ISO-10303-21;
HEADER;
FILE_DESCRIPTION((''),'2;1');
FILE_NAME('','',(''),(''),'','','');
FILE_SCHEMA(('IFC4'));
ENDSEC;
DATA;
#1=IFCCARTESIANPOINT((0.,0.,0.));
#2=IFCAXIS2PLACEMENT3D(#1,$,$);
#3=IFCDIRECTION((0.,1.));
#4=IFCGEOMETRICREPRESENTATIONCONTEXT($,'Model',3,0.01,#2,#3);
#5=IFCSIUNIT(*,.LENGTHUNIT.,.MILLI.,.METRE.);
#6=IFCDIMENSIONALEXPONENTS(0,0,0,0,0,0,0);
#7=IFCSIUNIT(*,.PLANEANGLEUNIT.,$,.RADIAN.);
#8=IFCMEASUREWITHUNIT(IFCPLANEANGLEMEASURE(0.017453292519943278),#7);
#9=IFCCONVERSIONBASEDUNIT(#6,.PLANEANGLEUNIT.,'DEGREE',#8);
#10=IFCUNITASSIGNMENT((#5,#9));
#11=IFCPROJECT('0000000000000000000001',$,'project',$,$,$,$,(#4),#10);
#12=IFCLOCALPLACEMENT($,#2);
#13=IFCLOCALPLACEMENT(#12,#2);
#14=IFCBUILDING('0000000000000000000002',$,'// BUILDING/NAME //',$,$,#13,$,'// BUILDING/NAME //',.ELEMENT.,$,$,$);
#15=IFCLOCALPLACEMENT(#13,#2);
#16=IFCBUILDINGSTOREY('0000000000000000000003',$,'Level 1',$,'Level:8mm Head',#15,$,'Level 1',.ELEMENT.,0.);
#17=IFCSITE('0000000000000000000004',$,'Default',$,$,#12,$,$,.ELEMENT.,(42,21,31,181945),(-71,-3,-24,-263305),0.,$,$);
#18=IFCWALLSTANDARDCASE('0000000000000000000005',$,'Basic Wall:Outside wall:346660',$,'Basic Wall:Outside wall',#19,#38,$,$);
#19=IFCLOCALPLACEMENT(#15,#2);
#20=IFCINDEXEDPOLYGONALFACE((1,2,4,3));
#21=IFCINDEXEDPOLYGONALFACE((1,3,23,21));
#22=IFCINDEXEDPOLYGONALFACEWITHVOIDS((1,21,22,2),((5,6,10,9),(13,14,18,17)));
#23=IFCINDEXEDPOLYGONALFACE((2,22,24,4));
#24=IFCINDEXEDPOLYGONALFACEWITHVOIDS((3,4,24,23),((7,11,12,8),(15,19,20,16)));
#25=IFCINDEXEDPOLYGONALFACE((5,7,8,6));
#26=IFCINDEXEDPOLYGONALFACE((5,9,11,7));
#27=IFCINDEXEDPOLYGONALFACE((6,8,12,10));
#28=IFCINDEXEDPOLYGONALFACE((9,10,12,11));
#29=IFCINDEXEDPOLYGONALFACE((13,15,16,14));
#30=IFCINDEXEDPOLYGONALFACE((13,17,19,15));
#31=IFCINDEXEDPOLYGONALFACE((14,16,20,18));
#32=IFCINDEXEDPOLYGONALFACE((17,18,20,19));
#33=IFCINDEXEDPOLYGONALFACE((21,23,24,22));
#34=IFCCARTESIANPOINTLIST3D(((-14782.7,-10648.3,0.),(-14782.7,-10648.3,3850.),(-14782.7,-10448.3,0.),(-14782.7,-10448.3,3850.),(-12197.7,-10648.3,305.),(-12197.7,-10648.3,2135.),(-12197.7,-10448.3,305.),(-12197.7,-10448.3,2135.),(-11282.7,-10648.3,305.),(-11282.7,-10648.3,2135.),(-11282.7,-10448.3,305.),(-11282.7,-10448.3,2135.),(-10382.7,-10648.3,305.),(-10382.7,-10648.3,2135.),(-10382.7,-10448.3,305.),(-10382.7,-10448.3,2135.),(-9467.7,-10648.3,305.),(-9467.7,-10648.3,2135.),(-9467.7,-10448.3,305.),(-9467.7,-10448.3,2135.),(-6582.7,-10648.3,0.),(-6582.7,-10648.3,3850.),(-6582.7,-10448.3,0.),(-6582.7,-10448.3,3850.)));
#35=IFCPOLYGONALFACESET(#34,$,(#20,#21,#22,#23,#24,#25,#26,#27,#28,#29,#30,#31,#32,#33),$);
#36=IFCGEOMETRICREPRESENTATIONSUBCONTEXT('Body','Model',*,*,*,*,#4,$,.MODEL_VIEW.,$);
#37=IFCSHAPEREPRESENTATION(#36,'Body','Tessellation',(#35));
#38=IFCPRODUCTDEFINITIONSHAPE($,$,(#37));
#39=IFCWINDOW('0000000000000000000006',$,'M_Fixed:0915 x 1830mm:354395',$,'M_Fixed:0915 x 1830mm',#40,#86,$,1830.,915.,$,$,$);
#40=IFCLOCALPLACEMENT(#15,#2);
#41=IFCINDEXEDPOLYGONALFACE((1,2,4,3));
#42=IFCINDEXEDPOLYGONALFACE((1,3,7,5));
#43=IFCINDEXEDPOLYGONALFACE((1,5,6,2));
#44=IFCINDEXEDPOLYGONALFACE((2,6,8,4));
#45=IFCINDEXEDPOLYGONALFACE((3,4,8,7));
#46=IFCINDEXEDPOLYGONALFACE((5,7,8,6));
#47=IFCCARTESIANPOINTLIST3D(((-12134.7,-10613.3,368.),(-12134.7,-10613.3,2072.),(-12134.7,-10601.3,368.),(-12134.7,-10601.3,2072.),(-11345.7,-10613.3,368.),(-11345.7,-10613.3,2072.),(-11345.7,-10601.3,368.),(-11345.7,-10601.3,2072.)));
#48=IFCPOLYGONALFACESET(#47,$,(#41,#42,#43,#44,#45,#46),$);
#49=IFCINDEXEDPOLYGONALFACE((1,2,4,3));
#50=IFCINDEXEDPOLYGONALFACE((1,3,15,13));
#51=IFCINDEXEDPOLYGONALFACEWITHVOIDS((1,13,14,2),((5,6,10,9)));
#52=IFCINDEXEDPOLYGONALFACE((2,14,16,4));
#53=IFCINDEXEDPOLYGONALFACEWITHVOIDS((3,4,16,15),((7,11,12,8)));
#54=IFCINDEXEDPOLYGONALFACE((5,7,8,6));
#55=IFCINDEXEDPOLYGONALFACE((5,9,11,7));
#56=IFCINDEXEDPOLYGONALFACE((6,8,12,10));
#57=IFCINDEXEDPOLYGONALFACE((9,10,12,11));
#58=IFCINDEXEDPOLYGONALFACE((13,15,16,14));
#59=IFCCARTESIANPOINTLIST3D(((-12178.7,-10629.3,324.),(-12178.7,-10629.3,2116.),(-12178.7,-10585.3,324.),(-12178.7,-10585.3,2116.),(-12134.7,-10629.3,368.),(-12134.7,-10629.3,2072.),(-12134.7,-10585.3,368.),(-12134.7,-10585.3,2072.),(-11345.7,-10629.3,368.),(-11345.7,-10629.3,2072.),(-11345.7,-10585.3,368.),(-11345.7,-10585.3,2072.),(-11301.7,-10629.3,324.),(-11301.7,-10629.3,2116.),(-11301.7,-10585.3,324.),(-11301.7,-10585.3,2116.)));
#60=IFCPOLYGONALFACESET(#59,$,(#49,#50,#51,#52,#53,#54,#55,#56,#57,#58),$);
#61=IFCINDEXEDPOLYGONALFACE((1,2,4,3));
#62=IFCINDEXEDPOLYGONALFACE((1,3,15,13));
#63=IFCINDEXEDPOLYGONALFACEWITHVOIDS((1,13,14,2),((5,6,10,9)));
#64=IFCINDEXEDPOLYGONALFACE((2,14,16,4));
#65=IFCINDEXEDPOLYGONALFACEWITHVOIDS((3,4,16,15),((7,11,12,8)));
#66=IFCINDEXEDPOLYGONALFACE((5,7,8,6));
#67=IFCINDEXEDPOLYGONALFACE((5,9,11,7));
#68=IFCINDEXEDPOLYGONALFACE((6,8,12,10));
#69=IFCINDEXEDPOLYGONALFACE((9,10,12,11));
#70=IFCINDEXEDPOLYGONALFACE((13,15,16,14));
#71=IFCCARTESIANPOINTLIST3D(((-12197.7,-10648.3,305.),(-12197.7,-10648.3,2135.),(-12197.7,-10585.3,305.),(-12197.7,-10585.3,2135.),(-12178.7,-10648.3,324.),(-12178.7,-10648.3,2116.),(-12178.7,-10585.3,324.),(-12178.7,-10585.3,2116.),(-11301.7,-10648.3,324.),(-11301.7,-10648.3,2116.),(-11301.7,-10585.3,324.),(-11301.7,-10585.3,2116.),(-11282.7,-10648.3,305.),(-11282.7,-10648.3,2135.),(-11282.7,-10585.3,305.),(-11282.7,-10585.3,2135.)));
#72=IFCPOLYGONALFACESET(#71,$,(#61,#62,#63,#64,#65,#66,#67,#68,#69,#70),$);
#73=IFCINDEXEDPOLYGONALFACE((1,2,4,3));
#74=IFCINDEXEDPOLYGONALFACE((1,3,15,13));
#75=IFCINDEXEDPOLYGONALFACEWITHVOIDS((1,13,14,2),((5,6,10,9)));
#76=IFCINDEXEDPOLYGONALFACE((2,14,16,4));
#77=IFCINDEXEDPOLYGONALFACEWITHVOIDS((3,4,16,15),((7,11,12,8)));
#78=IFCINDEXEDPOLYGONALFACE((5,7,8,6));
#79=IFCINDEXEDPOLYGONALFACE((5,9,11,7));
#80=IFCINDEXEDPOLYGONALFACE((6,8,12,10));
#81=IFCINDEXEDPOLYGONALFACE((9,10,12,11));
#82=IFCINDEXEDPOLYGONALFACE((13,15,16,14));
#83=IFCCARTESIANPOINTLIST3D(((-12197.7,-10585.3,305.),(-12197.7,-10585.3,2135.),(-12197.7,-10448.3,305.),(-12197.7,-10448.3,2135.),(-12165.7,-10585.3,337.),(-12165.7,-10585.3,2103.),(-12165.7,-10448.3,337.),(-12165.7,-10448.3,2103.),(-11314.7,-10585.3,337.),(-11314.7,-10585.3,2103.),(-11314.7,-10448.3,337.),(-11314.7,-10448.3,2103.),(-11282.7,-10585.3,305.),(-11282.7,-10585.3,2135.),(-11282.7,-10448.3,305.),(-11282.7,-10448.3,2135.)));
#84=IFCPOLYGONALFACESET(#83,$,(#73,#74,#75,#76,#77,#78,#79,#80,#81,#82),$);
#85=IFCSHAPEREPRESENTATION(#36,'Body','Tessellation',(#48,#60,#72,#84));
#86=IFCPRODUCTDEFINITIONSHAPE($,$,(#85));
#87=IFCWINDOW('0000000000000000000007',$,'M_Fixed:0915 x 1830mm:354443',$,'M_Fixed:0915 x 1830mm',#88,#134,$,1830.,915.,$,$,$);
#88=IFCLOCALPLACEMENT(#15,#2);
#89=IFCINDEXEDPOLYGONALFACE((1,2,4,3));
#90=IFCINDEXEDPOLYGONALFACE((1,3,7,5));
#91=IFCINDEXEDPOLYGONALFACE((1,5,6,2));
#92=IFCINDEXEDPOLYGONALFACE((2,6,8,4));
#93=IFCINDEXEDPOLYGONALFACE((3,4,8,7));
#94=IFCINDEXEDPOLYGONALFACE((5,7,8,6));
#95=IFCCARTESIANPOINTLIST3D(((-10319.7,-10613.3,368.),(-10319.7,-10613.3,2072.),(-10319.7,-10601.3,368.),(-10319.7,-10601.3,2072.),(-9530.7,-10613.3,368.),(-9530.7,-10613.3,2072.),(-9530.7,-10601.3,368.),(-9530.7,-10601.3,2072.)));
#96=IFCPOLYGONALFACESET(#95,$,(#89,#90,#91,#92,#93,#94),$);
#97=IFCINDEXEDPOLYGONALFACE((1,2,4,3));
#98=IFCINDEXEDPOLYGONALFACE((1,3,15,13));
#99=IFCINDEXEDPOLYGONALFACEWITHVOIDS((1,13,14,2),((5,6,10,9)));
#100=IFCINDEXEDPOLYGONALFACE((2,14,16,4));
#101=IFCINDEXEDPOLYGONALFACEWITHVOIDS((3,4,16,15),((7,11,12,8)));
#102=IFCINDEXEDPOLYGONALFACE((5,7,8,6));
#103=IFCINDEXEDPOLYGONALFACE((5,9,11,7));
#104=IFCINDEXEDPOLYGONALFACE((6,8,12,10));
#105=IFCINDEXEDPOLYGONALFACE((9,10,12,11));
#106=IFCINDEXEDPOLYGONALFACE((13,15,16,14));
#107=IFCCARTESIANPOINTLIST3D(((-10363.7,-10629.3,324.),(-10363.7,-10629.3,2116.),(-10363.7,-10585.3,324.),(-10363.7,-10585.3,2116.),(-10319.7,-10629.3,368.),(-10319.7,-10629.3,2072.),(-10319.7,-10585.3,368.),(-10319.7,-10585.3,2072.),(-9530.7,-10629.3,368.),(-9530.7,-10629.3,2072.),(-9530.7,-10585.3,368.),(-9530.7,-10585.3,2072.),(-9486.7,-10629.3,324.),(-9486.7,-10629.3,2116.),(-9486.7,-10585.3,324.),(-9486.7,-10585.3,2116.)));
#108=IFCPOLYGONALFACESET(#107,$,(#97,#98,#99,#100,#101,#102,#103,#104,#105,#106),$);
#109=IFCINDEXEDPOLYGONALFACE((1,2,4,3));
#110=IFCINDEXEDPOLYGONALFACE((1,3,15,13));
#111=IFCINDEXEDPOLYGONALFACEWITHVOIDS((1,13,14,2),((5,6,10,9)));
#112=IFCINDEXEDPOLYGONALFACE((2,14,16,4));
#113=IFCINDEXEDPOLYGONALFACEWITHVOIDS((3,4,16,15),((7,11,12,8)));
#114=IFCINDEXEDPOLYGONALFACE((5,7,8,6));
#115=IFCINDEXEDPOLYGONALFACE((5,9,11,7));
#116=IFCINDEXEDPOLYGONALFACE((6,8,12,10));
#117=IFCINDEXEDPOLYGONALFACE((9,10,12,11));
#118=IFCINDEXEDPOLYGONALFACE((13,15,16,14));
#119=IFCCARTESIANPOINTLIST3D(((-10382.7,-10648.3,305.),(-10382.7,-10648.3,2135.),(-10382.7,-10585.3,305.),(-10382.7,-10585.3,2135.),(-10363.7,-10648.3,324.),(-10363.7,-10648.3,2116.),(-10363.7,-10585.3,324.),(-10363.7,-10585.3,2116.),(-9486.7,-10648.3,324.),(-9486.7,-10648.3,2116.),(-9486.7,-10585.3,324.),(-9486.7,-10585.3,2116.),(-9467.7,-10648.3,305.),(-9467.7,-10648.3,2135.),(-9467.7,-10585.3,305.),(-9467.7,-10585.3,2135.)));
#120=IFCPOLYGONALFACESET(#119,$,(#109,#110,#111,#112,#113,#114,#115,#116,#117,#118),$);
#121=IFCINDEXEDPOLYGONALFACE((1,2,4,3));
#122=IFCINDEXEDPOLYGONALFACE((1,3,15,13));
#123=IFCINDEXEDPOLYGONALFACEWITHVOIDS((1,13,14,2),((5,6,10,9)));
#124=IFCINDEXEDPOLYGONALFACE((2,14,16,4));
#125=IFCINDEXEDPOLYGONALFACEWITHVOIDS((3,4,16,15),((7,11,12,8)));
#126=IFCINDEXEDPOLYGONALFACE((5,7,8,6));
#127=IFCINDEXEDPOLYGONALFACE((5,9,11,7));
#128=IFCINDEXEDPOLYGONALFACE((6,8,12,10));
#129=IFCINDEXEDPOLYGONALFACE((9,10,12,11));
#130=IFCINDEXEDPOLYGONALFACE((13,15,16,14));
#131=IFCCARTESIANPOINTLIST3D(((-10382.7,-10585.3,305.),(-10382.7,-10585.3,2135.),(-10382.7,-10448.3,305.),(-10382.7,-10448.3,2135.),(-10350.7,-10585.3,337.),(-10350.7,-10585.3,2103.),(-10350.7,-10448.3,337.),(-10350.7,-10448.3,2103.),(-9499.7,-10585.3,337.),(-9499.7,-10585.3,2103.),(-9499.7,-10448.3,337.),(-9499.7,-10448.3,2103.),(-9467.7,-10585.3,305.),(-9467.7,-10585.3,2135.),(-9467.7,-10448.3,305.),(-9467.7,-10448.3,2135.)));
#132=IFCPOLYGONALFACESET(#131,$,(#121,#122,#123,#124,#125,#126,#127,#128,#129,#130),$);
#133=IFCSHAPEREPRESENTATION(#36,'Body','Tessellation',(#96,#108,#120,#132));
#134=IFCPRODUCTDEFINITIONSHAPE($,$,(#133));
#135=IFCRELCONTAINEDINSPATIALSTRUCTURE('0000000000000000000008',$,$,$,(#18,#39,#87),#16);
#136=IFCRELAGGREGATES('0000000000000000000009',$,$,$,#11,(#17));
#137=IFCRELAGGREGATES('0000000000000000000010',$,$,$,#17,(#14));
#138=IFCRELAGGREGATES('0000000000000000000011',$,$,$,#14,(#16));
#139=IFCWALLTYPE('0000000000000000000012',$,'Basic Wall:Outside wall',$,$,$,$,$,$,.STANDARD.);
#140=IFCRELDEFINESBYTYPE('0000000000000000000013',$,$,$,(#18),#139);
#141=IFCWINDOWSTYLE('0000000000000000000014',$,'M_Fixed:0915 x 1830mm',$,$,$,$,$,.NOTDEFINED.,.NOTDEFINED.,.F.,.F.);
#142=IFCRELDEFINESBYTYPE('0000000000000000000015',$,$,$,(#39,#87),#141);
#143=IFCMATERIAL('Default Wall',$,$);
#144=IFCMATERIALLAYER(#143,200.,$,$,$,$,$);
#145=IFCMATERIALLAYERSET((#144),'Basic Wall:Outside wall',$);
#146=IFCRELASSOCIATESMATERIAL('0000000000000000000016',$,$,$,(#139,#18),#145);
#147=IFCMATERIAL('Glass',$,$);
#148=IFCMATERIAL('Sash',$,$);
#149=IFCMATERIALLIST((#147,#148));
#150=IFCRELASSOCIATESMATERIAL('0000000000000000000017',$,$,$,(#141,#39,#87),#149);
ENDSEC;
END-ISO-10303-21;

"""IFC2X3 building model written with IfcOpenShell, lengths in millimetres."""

from ifc_helpers import new_model, entity, si_unit, converted_unit, direction, frame, frame_2d, origin, place, context, subcontext, project, spatial, polyline, rectangle, outline, extrude, clip, bounded_halfspace, source, transform, mapped, material, material_list, layer, layer_set, layer_usage, type_object, type_shapes, element, fill, save


model = new_model("IFC2X3")

# Units and contexts
model_context = context("Model", 3, precision=0.01, world=origin(), true_north=direction((0.0, 1.0)))
body_context = subcontext(model_context, "Body", "Model", "MODEL_VIEW")
ifc_project = project(units=[si_unit("LENGTHUNIT", "METRE", prefix="MILLI"), converted_unit("PLANEANGLEUNIT", "DEGREE", entity("IfcPlaneAngleMeasure", 0.017453292519943278), si_unit("PLANEANGLEUNIT", "RADIAN"), dimensions=[0, 0, 0, 0, 0, 0, 0])], contexts=[model_context])

# Site, building, storey
site_placement = place(None, origin())
site = spatial("IfcSite", under=ifc_project, at=site_placement, Name="Default", CompositionType="ELEMENT", RefLatitude=(42, 21, 31, 181945), RefLongitude=(-71, -3, -24, -263305), RefElevation=0.0)
building_placement = place(site_placement, origin())
building = spatial("IfcBuilding", under=site, at=building_placement, Name="// BUILDING/NAME //", LongName="// BUILDING/NAME //", CompositionType="ELEMENT")
storey_placement = place(building_placement, origin())
storey = spatial("IfcBuildingStorey", under=building, at=storey_placement, Name="Level 1", ObjectType="Level:8mm Head", LongName="Level 1", CompositionType="ELEMENT", Elevation=0.0)

# Wall, openings, windows
ifc_material_1 = material(Name="Default Wall")
ifc_layer = layer(ifc_material_1, 200.0)
ifc_layer_set = layer_set([ifc_layer], Name="Basic Wall:Outside wall")
ifc_layer_usage = layer_usage(ifc_layer_set, "AXIS2", "NEGATIVE", 100.0)
wall_type = type_object("IfcWallType", Name="Basic Wall:Outside wall", PredefinedType="STANDARD", material=ifc_layer_set)
wall_1_placement = place(storey_placement, frame((-14782.7, -10548.3, 0.0)))
wall_1 = element("IfcWallStandardCase", 1, at=wall_1_placement, inside=storey, type_object=wall_type, material=ifc_layer_usage, Name="Basic Wall:Outside wall:346660", ObjectType="Basic Wall:Outside wall", context=body_context, shape_type="Clipping", body=[
    clip(extrude(rectangle(XDim=8200.0, YDim=200.0, at=frame_2d((4100.0, 0.0), x_axis=(-1.0, 0.0))), origin(), (0.0, 0.0, 1.0), 3850.0), bounded_halfspace(frame((0.0, -100.0, 3850.0), z_axis=(0.0, 0.0, -1.0), x_axis=(1.0, 0.0, 0.0)), True, frame((0.0, -100.0, 3850.0)), polyline([(0.0, 0.0), (8200.0, 0.0), (8200.0, 200.0), (8000.0, 200.0), (200.0, 200.0), (0.0, 200.0), (0.0, 0.0)]))),
])
opening_1_placement = place(wall_1_placement, frame((3500.0, 100.0, 305.0)))
opening_1 = element("IfcOpeningElement", 2, at=opening_1_placement, cuts=wall_1, ObjectType="Opening", context=body_context, shape_type="SweptSolid", body=[
    extrude(rectangle(XDim=1830.0, YDim=915.0, at=frame_2d((915.0, 457.5), x_axis=(1.0, 0.0))), frame((0.0, 0.0, 0.0), z_axis=(0.0, -1.0, 0.0), x_axis=(0.0, 0.0, 1.0)), (0.0, 0.0, 1.0), 200.0),
])
opening_2_placement = place(wall_1_placement, frame((5315.0, 100.0, 305.0)))
opening_2 = element("IfcOpeningElement", 3, at=opening_2_placement, cuts=wall_1, ObjectType="Opening", context=body_context, shape_type="SweptSolid", body=[
    extrude(rectangle(XDim=1830.0, YDim=915.0, at=frame_2d((915.0, 457.5), x_axis=(1.0, 0.0))), frame((0.0, 0.0, 0.0), z_axis=(0.0, -1.0, 0.0), x_axis=(0.0, 0.0, 1.0)), (0.0, 0.0, 1.0), 200.0),
])
ifc_material_2 = material(Name="Glass")
ifc_material_3 = material(Name="Sash")
ifc_material_list_1 = material_list([ifc_material_2, ifc_material_3])
window_style = type_object("IfcWindowStyle", Name="M_Fixed:0915 x 1830mm", ConstructionType="NOTDEFINED", OperationType="NOTDEFINED", ParameterTakesPrecedence=False, Sizeable=False, material=ifc_material_list_1)
shared_shape_1 = source(origin(), body_context, "Body", "SweptSolid", [
    extrude(rectangle(XDim=12.0, YDim=789.0, at=frame_2d((0.0, 0.0), x_axis=(1.0, 0.0))), frame((457.5, 159.0, 63.0), z_axis=(0.0, 0.0, 1.0), x_axis=(0.0, -1.0, 0.0)), (0.0, 0.0, 1.0), 1704.0),
    extrude(outline(polyline([(-438.5, -896.0), (438.5, -896.0), (438.5, 896.0), (-438.5, 896.0), (-438.5, -896.0)]), holes=[polyline([(-394.5, -852.0), (-394.5, 852.0), (394.5, 852.0), (394.5, -852.0), (-394.5, -852.0)])]), frame((457.5, 137.0, 915.0), z_axis=(0.0, 1.0, 0.0), x_axis=(1.0, 0.0, 0.0)), (0.0, 0.0, 1.0), 44.0),
    extrude(outline(polyline([(-457.5, -915.0), (457.5, -915.0), (457.5, 915.0), (-457.5, 915.0), (-457.5, -915.0)]), holes=[polyline([(-438.5, -896.0), (-438.5, 896.0), (438.5, 896.0), (438.5, -896.0), (-438.5, -896.0)])]), frame((457.5, 137.0, 915.0), z_axis=(0.0, 1.0, 0.0), x_axis=(1.0, 0.0, 0.0)), (0.0, 0.0, 1.0), 63.0),
    extrude(outline(polyline([(-457.5, -915.0), (457.5, -915.0), (457.5, 915.0), (-457.5, 915.0), (-457.5, -915.0)]), holes=[polyline([(-425.5, -883.0), (-425.5, 883.0), (425.5, 883.0), (425.5, -883.0), (-425.5, -883.0)])]), frame((457.5, 0.0, 915.0), z_axis=(0.0, 1.0, 0.0), x_axis=(1.0, 0.0, 0.0)), (0.0, 0.0, 1.0), 137.0),
])
type_shapes(window_style, [shared_shape_1])
window_1_placement = place(opening_1_placement, frame((0.0, 0.0, 0.0), z_axis=(0.0, 0.0, 1.0), x_axis=(-1.0, 0.0, 0.0)))
window_1 = element("IfcWindow", 4, at=window_1_placement, inside=storey, type_object=window_style, material=ifc_material_list_1, Name="M_Fixed:0915 x 1830mm:354395", ObjectType="M_Fixed:0915 x 1830mm", OverallHeight=1830.0, OverallWidth=915.0, context=body_context, shape_type="MappedRepresentation", body=[
    mapped(shared_shape_1, transform((0.0, 0.0, 0.0), scale=1.0)),
])
fill(opening_1, window_1)
window_2_placement = place(opening_2_placement, frame((0.0, 0.0, 0.0), z_axis=(0.0, 0.0, 1.0), x_axis=(-1.0, 0.0, 0.0)))
window_2 = element("IfcWindow", 5, at=window_2_placement, inside=storey, type_object=window_style, material=ifc_material_list_1, Name="M_Fixed:0915 x 1830mm:354443", ObjectType="M_Fixed:0915 x 1830mm", OverallHeight=1830.0, OverallWidth=915.0, context=body_context, shape_type="MappedRepresentation", body=[
    mapped(shared_shape_1, transform((0.0, 0.0, 0.0), scale=1.0)),
])
fill(opening_2, window_2)

save(model, "model.ifc")
